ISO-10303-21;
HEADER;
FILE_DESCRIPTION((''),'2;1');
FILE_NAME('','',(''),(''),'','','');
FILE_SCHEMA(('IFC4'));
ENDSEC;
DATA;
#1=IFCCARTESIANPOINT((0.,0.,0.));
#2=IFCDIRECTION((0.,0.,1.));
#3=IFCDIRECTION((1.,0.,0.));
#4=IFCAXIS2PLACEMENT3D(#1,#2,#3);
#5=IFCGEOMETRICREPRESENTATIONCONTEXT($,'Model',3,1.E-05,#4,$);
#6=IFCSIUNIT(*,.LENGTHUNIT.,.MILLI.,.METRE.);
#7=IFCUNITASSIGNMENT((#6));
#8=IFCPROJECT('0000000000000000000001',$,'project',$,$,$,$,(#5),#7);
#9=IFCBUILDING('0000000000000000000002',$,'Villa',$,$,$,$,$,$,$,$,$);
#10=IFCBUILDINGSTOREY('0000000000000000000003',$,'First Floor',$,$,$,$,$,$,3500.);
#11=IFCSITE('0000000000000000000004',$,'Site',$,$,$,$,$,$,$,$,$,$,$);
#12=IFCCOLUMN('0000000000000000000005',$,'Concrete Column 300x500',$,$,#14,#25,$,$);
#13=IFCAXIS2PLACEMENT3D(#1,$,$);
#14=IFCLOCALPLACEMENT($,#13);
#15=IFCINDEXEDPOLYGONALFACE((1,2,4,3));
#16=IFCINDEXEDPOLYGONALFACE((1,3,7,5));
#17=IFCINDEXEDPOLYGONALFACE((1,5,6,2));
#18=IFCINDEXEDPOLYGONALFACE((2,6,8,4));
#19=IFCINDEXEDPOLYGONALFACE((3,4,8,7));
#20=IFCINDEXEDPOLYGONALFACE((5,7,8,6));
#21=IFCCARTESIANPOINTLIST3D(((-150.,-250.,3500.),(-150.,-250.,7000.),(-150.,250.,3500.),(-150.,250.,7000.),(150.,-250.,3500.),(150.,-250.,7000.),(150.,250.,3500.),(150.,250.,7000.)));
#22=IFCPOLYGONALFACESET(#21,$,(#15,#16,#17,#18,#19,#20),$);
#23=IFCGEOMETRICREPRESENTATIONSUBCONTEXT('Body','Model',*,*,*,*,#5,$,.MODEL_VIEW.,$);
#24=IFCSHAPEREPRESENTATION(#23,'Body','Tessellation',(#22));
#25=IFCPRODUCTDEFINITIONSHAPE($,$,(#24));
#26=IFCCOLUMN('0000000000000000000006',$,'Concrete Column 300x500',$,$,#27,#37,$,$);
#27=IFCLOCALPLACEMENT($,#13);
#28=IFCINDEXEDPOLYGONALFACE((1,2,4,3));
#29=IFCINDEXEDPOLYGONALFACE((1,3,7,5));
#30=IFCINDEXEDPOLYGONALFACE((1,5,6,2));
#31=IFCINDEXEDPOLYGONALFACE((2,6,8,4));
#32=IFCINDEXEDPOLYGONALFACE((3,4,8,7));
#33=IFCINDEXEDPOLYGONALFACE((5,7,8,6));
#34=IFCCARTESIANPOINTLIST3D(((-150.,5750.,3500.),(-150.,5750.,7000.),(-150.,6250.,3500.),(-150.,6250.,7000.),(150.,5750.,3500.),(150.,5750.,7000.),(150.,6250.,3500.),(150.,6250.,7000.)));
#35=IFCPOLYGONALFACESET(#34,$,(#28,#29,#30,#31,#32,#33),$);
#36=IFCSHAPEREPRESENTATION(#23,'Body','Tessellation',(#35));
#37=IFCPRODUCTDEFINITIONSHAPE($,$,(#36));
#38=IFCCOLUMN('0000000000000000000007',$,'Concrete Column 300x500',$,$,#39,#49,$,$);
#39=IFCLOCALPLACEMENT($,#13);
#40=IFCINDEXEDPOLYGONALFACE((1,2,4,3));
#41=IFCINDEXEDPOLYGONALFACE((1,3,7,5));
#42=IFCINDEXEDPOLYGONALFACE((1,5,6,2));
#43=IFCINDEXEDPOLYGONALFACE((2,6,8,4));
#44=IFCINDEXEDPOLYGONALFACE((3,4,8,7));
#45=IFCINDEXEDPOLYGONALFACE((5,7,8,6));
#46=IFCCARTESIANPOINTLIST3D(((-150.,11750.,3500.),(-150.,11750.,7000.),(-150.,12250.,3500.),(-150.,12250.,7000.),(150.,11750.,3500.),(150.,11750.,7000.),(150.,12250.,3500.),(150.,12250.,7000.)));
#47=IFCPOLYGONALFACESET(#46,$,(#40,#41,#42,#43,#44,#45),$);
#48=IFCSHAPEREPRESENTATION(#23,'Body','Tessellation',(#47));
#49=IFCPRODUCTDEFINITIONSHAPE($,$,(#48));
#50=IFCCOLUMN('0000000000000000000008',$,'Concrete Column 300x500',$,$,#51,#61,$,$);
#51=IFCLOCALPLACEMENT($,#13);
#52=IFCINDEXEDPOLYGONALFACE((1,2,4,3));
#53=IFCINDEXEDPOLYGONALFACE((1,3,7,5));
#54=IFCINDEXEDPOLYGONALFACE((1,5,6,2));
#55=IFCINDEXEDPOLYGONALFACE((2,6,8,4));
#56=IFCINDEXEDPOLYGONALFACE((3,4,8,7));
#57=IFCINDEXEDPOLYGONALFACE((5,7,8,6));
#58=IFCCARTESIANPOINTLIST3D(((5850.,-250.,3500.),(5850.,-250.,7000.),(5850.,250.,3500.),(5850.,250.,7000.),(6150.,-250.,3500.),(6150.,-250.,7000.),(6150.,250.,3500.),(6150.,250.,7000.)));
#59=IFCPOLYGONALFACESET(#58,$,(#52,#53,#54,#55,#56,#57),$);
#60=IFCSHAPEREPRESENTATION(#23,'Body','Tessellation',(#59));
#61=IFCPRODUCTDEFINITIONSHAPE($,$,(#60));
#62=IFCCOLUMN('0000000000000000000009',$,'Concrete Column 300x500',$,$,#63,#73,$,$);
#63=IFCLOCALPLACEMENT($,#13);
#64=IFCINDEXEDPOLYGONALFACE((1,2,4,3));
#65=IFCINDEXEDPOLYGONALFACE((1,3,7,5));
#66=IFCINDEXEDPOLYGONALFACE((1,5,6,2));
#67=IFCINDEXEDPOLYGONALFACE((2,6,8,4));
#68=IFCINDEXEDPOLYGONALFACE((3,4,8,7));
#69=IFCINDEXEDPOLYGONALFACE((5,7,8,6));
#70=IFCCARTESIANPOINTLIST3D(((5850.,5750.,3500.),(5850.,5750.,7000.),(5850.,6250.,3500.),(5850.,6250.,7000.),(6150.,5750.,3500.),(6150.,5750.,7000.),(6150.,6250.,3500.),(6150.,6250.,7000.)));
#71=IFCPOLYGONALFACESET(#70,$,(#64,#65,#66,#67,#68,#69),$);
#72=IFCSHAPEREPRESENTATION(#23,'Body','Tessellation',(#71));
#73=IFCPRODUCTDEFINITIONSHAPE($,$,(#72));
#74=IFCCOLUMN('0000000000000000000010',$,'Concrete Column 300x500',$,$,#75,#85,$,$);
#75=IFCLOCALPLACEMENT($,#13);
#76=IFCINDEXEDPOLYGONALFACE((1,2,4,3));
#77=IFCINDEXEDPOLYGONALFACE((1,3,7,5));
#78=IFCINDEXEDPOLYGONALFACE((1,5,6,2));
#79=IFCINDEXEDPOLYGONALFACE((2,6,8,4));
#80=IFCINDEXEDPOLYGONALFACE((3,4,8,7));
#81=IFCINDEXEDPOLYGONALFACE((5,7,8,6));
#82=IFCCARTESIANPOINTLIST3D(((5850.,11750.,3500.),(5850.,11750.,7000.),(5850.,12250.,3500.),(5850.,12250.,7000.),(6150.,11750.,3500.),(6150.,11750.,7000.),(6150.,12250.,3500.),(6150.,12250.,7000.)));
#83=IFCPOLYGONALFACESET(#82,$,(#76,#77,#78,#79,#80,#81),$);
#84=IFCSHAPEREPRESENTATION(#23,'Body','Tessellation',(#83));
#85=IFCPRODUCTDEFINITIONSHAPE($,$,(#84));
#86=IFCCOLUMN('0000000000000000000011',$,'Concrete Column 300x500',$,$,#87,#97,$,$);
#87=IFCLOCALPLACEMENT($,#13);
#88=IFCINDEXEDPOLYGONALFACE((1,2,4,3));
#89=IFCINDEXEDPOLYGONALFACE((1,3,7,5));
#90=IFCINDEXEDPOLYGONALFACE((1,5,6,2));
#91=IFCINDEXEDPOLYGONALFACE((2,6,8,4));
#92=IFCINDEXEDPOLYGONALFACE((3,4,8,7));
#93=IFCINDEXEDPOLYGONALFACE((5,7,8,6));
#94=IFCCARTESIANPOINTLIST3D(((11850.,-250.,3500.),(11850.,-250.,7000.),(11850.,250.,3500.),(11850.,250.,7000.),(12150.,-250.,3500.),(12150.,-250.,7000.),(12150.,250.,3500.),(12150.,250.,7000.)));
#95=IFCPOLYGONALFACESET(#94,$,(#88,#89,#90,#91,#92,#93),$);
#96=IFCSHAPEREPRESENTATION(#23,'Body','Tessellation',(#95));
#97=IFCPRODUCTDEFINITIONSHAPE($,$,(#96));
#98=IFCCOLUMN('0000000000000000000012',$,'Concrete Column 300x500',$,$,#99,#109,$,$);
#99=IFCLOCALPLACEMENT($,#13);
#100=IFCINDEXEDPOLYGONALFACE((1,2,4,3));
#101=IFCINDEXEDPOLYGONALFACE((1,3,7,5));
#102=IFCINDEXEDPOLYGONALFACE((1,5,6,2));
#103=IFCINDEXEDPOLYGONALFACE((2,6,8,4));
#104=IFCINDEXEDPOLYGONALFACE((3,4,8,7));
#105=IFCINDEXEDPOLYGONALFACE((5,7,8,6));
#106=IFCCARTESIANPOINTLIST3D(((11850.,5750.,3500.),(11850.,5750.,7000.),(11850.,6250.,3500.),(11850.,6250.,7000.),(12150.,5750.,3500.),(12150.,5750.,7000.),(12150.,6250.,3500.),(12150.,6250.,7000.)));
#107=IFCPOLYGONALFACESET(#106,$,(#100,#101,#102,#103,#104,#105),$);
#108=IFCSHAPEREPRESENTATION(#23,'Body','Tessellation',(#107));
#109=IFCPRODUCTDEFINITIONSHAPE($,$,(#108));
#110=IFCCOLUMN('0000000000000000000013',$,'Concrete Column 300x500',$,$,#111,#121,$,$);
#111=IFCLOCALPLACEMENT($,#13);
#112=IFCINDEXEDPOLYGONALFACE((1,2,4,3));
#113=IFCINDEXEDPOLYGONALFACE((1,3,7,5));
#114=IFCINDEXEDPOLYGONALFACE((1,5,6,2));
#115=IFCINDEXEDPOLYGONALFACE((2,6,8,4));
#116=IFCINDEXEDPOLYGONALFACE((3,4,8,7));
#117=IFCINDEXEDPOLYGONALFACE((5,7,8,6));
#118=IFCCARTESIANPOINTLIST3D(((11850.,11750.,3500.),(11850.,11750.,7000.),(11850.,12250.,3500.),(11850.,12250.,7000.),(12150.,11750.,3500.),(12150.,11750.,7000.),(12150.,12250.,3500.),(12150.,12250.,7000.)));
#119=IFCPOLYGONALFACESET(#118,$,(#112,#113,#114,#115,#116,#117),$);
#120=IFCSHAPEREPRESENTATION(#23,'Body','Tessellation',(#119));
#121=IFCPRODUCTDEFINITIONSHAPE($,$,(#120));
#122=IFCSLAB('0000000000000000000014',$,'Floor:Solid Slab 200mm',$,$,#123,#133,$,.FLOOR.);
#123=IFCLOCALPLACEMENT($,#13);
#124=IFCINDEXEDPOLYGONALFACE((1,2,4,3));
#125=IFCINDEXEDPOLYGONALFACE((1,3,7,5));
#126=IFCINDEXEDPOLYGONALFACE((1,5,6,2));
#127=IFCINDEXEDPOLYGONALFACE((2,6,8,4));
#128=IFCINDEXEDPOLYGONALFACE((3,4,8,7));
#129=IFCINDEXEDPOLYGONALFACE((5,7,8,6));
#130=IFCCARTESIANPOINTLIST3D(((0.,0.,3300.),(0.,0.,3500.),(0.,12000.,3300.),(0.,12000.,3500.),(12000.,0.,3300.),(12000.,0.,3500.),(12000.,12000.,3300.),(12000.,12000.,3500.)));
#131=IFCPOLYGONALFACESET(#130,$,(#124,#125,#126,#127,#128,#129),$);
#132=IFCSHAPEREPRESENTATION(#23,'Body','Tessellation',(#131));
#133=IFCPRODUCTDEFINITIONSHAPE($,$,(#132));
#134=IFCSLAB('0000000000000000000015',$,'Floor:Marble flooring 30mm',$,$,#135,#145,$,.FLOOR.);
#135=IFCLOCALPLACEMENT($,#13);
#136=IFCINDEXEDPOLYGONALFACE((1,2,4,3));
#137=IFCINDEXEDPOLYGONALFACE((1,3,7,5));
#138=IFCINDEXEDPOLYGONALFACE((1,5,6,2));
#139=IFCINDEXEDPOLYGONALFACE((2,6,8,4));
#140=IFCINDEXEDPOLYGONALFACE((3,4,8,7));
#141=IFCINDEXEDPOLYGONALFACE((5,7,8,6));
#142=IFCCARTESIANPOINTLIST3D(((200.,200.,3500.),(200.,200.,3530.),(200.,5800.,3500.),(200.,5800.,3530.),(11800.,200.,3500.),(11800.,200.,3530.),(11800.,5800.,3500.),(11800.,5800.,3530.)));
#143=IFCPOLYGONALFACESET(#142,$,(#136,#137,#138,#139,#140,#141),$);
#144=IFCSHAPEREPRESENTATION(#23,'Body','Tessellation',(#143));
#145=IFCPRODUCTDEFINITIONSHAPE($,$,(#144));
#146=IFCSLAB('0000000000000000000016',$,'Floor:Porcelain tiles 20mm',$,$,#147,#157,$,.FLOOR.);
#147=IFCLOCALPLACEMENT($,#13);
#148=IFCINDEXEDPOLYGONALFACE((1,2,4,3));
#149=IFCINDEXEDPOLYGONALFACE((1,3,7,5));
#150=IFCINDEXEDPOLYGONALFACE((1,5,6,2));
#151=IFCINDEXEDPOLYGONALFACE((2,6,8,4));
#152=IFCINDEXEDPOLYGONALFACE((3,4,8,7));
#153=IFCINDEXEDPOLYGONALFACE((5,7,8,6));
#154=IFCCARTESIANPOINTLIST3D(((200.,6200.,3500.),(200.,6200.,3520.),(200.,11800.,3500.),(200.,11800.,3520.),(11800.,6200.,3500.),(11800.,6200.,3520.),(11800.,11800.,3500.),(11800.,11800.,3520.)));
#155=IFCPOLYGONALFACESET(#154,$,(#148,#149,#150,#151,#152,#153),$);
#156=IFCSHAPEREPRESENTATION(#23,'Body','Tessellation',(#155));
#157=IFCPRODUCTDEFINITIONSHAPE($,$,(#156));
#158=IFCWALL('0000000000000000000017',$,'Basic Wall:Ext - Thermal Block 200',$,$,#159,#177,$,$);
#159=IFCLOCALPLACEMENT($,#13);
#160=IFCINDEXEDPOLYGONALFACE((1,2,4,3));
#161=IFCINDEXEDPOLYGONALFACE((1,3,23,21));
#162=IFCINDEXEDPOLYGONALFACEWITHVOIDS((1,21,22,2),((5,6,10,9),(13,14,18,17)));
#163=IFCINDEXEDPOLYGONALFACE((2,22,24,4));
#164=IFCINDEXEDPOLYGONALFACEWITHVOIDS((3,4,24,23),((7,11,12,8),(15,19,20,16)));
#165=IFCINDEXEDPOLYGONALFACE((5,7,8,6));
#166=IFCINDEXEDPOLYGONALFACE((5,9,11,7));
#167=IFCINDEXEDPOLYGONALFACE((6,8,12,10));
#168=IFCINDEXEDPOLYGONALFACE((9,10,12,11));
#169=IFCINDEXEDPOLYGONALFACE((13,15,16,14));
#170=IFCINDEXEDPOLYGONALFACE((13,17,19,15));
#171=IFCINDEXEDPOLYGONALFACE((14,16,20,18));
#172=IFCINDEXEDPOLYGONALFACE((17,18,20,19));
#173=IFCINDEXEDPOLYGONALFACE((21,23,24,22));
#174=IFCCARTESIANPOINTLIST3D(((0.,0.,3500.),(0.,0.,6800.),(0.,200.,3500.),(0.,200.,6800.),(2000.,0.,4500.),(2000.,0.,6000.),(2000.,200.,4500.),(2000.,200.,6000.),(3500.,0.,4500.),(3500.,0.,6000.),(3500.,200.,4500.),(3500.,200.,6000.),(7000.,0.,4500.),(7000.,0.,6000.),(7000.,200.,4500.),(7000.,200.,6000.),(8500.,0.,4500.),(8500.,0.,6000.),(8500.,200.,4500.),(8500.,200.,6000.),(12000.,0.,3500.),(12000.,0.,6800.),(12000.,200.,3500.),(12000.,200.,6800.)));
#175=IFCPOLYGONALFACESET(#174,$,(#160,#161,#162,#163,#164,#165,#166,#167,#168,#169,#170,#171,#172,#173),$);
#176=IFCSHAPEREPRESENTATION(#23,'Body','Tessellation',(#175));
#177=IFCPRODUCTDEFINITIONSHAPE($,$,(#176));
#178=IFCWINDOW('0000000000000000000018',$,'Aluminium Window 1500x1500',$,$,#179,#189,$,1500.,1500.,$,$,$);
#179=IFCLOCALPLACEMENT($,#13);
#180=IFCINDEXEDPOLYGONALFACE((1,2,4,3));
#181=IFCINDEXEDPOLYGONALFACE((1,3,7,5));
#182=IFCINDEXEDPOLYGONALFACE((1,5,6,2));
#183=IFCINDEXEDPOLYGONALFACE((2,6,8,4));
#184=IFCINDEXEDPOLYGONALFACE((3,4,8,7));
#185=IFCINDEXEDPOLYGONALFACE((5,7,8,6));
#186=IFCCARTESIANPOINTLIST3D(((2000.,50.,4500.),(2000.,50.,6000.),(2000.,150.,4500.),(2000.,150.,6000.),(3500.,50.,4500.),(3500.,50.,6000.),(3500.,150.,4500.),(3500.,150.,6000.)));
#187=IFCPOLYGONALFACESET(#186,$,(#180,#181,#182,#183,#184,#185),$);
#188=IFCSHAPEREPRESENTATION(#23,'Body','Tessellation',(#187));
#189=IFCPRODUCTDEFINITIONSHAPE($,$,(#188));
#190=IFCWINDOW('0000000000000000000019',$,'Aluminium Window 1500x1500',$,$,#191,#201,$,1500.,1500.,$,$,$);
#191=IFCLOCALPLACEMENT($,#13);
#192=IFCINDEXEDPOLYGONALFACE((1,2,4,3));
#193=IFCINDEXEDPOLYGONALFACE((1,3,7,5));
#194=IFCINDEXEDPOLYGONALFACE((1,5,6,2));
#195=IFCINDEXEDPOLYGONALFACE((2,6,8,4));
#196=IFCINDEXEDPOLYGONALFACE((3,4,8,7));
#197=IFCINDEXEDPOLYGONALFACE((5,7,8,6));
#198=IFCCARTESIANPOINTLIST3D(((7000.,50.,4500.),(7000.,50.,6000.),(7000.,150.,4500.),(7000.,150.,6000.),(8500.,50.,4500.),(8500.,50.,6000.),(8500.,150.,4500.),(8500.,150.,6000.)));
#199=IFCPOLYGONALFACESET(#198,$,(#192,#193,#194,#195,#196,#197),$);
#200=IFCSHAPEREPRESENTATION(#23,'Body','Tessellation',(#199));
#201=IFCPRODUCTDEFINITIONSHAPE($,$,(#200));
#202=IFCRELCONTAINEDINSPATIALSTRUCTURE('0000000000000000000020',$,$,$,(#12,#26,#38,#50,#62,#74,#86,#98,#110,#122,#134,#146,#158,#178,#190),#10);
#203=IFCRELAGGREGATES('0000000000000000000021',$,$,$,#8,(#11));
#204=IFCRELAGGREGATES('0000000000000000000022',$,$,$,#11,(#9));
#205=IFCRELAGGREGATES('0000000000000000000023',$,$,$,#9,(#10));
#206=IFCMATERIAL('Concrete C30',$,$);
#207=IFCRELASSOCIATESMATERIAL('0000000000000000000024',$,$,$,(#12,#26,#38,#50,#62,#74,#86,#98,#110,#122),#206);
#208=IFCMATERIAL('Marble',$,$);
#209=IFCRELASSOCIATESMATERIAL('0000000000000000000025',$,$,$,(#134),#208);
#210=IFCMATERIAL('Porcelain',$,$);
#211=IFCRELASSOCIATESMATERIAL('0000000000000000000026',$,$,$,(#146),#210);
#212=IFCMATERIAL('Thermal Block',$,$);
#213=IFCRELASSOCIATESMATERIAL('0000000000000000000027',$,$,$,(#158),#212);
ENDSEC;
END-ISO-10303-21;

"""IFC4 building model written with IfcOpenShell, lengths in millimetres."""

from ifc_helpers import new_model, si_unit, frame, origin_with_axes, place, context, subcontext, project, spatial, indexed_curve, outline, extrude, material, element, fill, save


model = new_model("IFC4")

# Units and contexts
model_context = context("Model", 3, precision=1e-05, world=origin_with_axes())
body_context = subcontext(model_context, "Body", "Model", "MODEL_VIEW")
ifc_project = project(units=[si_unit("LENGTHUNIT", "METRE", prefix="MILLI")], contexts=[model_context])

# Site, building, storey
site = spatial("IfcSite", under=ifc_project, Name="Site")
building = spatial("IfcBuilding", under=site, Name="Villa")
storey = spatial("IfcBuildingStorey", under=building, Name="First Floor", Elevation=3500.0)

# Columns
ifc_material_1 = material(Name="Concrete C30")
for number, where, z_axis, x_axis, name in (
    (1, (-150.0, -250.0, 3500.0), (0.0, 0.0, 1.0), (1.0, 0.0, 0.0), "Concrete Column 300x500"),
    (2, (-150.0, 5750.0, 3500.0), (0.0, 0.0, 1.0), (1.0, 0.0, 0.0), "Concrete Column 300x500"),
    (3, (-150.0, 11750.0, 3500.0), (0.0, 0.0, 1.0), (1.0, 0.0, 0.0), "Concrete Column 300x500"),
    (4, (5850.0, -250.0, 3500.0), (0.0, 0.0, 1.0), (1.0, 0.0, 0.0), "Concrete Column 300x500"),
    (5, (5850.0, 5750.0, 3500.0), (0.0, 0.0, 1.0), (1.0, 0.0, 0.0), "Concrete Column 300x500"),
    (6, (5850.0, 11750.0, 3500.0), (0.0, 0.0, 1.0), (1.0, 0.0, 0.0), "Concrete Column 300x500"),
    (7, (11850.0, -250.0, 3500.0), (0.0, 0.0, 1.0), (1.0, 0.0, 0.0), "Concrete Column 300x500"),
    (8, (11850.0, 5750.0, 3500.0), (0.0, 0.0, 1.0), (1.0, 0.0, 0.0), "Concrete Column 300x500"),
    (9, (11850.0, 11750.0, 3500.0), (0.0, 0.0, 1.0), (1.0, 0.0, 0.0), "Concrete Column 300x500"),
):
    element("IfcColumn", number, at=place(None, frame(where, z_axis=z_axis, x_axis=x_axis)), inside=storey, material=ifc_material_1, Name=name, context=body_context, shape_type="SweptSolid", body=[
        extrude(outline(indexed_curve([(0.0, 0.0), (0.0, 500.0), (300.0, 500.0), (300.0, 0.0), (0.0, 0.0)], self_intersect=False)), origin_with_axes(), (0.0, 0.0, 1.0), 3500.0),
    ])

# Slabs
slab_1_placement = place(None, frame((0.0, 0.0, 3300.0), z_axis=(0.0, 0.0, 1.0), x_axis=(1.0, 0.0, 0.0)))
element("IfcSlab", 10, at=slab_1_placement, inside=storey, material=ifc_material_1, Name="Floor:Solid Slab 200mm", PredefinedType="FLOOR", context=body_context, shape_type="SweptSolid", body=[
    extrude(outline(indexed_curve([(0.0, 0.0), (12000.0, 0.0), (12000.0, 12000.0), (0.0, 12000.0)])), None, (0.0, 0.0, 1.0), 200.0),
])
ifc_material_2 = material(Name="Marble")
slab_2_placement = place(None, frame((200.0, 200.0, 3500.0), z_axis=(0.0, 0.0, 1.0), x_axis=(1.0, 0.0, 0.0)))
element("IfcSlab", 11, at=slab_2_placement, inside=storey, material=ifc_material_2, Name="Floor:Marble flooring 30mm", PredefinedType="FLOOR", context=body_context, shape_type="SweptSolid", body=[
    extrude(outline(indexed_curve([(0.0, 0.0), (11600.0, 0.0), (11600.0, 5600.0), (0.0, 5600.0)])), None, (0.0, 0.0, 1.0), 30.0),
])
ifc_material_3 = material(Name="Porcelain")
slab_3_placement = place(None, frame((200.0, 6200.0, 3500.0), z_axis=(0.0, 0.0, 1.0), x_axis=(1.0, 0.0, 0.0)))
element("IfcSlab", 12, at=slab_3_placement, inside=storey, material=ifc_material_3, Name="Floor:Porcelain tiles 20mm", PredefinedType="FLOOR", context=body_context, shape_type="SweptSolid", body=[
    extrude(outline(indexed_curve([(0.0, 0.0), (11600.0, 0.0), (11600.0, 5600.0), (0.0, 5600.0)])), None, (0.0, 0.0, 1.0), 20.0),
])

# Wall, openings, windows
ifc_material_4 = material(Name="Thermal Block")
wall_1_placement = place(None, frame((0.0, 0.0, 3500.0), z_axis=(0.0, 0.0, 1.0), x_axis=(1.0, 0.0, 0.0)))
wall_1 = element("IfcWall", 13, at=wall_1_placement, inside=storey, material=ifc_material_4, Name="Basic Wall:Ext - Thermal Block 200", context=body_context, shape_type="SweptSolid", body=[
    extrude(outline(indexed_curve([(0.0, 0.0), (0.0, 200.0), (12000.0, 200.0), (12000.0, 0.0), (0.0, 0.0)], self_intersect=False)), origin_with_axes(), (0.0, 0.0, 1.0), 3300.0),
])
opening_1_placement = place(wall_1_placement, frame((2000.0, -200.0, 1000.0), z_axis=(0.0, 0.0, 1.0), x_axis=(1.0, 0.0, 0.0)))
opening_1 = element("IfcOpeningElement", 14, at=opening_1_placement, cuts=wall_1, context=body_context, shape_type="SweptSolid", body=[
    extrude(outline(indexed_curve([(0.0, 0.0), (0.0, 600.0), (1500.0, 600.0), (1500.0, 0.0), (0.0, 0.0)], self_intersect=False)), origin_with_axes(), (0.0, 0.0, 1.0), 1500.0),
])
opening_2_placement = place(wall_1_placement, frame((7000.0, -200.0, 1000.0), z_axis=(0.0, 0.0, 1.0), x_axis=(1.0, 0.0, 0.0)))
opening_2 = element("IfcOpeningElement", 15, at=opening_2_placement, cuts=wall_1, context=body_context, shape_type="SweptSolid", body=[
    extrude(outline(indexed_curve([(0.0, 0.0), (0.0, 600.0), (1500.0, 600.0), (1500.0, 0.0), (0.0, 0.0)], self_intersect=False)), origin_with_axes(), (0.0, 0.0, 1.0), 1500.0),
])
window_1_placement = place(None, frame((2000.0, 50.0, 4500.0), z_axis=(0.0, 0.0, 1.0), x_axis=(1.0, 0.0, 0.0)))
window_1 = element("IfcWindow", 16, at=window_1_placement, inside=storey, Name="Aluminium Window 1500x1500", OverallHeight=1500.0, OverallWidth=1500.0, context=body_context, shape_type="SweptSolid", body=[
    extrude(outline(indexed_curve([(0.0, 0.0), (0.0, 100.0), (1500.0, 100.0), (1500.0, 0.0), (0.0, 0.0)], self_intersect=False)), origin_with_axes(), (0.0, 0.0, 1.0), 1500.0),
])
fill(opening_1, window_1)
window_2_placement = place(None, frame((7000.0, 50.0, 4500.0), z_axis=(0.0, 0.0, 1.0), x_axis=(1.0, 0.0, 0.0)))
window_2 = element("IfcWindow", 17, at=window_2_placement, inside=storey, Name="Aluminium Window 1500x1500", OverallHeight=1500.0, OverallWidth=1500.0, context=body_context, shape_type="SweptSolid", body=[
    extrude(outline(indexed_curve([(0.0, 0.0), (0.0, 100.0), (1500.0, 100.0), (1500.0, 0.0), (0.0, 0.0)], self_intersect=False)), origin_with_axes(), (0.0, 0.0, 1.0), 1500.0),
])
fill(opening_2, window_2)

save(model, "model.ifc")
